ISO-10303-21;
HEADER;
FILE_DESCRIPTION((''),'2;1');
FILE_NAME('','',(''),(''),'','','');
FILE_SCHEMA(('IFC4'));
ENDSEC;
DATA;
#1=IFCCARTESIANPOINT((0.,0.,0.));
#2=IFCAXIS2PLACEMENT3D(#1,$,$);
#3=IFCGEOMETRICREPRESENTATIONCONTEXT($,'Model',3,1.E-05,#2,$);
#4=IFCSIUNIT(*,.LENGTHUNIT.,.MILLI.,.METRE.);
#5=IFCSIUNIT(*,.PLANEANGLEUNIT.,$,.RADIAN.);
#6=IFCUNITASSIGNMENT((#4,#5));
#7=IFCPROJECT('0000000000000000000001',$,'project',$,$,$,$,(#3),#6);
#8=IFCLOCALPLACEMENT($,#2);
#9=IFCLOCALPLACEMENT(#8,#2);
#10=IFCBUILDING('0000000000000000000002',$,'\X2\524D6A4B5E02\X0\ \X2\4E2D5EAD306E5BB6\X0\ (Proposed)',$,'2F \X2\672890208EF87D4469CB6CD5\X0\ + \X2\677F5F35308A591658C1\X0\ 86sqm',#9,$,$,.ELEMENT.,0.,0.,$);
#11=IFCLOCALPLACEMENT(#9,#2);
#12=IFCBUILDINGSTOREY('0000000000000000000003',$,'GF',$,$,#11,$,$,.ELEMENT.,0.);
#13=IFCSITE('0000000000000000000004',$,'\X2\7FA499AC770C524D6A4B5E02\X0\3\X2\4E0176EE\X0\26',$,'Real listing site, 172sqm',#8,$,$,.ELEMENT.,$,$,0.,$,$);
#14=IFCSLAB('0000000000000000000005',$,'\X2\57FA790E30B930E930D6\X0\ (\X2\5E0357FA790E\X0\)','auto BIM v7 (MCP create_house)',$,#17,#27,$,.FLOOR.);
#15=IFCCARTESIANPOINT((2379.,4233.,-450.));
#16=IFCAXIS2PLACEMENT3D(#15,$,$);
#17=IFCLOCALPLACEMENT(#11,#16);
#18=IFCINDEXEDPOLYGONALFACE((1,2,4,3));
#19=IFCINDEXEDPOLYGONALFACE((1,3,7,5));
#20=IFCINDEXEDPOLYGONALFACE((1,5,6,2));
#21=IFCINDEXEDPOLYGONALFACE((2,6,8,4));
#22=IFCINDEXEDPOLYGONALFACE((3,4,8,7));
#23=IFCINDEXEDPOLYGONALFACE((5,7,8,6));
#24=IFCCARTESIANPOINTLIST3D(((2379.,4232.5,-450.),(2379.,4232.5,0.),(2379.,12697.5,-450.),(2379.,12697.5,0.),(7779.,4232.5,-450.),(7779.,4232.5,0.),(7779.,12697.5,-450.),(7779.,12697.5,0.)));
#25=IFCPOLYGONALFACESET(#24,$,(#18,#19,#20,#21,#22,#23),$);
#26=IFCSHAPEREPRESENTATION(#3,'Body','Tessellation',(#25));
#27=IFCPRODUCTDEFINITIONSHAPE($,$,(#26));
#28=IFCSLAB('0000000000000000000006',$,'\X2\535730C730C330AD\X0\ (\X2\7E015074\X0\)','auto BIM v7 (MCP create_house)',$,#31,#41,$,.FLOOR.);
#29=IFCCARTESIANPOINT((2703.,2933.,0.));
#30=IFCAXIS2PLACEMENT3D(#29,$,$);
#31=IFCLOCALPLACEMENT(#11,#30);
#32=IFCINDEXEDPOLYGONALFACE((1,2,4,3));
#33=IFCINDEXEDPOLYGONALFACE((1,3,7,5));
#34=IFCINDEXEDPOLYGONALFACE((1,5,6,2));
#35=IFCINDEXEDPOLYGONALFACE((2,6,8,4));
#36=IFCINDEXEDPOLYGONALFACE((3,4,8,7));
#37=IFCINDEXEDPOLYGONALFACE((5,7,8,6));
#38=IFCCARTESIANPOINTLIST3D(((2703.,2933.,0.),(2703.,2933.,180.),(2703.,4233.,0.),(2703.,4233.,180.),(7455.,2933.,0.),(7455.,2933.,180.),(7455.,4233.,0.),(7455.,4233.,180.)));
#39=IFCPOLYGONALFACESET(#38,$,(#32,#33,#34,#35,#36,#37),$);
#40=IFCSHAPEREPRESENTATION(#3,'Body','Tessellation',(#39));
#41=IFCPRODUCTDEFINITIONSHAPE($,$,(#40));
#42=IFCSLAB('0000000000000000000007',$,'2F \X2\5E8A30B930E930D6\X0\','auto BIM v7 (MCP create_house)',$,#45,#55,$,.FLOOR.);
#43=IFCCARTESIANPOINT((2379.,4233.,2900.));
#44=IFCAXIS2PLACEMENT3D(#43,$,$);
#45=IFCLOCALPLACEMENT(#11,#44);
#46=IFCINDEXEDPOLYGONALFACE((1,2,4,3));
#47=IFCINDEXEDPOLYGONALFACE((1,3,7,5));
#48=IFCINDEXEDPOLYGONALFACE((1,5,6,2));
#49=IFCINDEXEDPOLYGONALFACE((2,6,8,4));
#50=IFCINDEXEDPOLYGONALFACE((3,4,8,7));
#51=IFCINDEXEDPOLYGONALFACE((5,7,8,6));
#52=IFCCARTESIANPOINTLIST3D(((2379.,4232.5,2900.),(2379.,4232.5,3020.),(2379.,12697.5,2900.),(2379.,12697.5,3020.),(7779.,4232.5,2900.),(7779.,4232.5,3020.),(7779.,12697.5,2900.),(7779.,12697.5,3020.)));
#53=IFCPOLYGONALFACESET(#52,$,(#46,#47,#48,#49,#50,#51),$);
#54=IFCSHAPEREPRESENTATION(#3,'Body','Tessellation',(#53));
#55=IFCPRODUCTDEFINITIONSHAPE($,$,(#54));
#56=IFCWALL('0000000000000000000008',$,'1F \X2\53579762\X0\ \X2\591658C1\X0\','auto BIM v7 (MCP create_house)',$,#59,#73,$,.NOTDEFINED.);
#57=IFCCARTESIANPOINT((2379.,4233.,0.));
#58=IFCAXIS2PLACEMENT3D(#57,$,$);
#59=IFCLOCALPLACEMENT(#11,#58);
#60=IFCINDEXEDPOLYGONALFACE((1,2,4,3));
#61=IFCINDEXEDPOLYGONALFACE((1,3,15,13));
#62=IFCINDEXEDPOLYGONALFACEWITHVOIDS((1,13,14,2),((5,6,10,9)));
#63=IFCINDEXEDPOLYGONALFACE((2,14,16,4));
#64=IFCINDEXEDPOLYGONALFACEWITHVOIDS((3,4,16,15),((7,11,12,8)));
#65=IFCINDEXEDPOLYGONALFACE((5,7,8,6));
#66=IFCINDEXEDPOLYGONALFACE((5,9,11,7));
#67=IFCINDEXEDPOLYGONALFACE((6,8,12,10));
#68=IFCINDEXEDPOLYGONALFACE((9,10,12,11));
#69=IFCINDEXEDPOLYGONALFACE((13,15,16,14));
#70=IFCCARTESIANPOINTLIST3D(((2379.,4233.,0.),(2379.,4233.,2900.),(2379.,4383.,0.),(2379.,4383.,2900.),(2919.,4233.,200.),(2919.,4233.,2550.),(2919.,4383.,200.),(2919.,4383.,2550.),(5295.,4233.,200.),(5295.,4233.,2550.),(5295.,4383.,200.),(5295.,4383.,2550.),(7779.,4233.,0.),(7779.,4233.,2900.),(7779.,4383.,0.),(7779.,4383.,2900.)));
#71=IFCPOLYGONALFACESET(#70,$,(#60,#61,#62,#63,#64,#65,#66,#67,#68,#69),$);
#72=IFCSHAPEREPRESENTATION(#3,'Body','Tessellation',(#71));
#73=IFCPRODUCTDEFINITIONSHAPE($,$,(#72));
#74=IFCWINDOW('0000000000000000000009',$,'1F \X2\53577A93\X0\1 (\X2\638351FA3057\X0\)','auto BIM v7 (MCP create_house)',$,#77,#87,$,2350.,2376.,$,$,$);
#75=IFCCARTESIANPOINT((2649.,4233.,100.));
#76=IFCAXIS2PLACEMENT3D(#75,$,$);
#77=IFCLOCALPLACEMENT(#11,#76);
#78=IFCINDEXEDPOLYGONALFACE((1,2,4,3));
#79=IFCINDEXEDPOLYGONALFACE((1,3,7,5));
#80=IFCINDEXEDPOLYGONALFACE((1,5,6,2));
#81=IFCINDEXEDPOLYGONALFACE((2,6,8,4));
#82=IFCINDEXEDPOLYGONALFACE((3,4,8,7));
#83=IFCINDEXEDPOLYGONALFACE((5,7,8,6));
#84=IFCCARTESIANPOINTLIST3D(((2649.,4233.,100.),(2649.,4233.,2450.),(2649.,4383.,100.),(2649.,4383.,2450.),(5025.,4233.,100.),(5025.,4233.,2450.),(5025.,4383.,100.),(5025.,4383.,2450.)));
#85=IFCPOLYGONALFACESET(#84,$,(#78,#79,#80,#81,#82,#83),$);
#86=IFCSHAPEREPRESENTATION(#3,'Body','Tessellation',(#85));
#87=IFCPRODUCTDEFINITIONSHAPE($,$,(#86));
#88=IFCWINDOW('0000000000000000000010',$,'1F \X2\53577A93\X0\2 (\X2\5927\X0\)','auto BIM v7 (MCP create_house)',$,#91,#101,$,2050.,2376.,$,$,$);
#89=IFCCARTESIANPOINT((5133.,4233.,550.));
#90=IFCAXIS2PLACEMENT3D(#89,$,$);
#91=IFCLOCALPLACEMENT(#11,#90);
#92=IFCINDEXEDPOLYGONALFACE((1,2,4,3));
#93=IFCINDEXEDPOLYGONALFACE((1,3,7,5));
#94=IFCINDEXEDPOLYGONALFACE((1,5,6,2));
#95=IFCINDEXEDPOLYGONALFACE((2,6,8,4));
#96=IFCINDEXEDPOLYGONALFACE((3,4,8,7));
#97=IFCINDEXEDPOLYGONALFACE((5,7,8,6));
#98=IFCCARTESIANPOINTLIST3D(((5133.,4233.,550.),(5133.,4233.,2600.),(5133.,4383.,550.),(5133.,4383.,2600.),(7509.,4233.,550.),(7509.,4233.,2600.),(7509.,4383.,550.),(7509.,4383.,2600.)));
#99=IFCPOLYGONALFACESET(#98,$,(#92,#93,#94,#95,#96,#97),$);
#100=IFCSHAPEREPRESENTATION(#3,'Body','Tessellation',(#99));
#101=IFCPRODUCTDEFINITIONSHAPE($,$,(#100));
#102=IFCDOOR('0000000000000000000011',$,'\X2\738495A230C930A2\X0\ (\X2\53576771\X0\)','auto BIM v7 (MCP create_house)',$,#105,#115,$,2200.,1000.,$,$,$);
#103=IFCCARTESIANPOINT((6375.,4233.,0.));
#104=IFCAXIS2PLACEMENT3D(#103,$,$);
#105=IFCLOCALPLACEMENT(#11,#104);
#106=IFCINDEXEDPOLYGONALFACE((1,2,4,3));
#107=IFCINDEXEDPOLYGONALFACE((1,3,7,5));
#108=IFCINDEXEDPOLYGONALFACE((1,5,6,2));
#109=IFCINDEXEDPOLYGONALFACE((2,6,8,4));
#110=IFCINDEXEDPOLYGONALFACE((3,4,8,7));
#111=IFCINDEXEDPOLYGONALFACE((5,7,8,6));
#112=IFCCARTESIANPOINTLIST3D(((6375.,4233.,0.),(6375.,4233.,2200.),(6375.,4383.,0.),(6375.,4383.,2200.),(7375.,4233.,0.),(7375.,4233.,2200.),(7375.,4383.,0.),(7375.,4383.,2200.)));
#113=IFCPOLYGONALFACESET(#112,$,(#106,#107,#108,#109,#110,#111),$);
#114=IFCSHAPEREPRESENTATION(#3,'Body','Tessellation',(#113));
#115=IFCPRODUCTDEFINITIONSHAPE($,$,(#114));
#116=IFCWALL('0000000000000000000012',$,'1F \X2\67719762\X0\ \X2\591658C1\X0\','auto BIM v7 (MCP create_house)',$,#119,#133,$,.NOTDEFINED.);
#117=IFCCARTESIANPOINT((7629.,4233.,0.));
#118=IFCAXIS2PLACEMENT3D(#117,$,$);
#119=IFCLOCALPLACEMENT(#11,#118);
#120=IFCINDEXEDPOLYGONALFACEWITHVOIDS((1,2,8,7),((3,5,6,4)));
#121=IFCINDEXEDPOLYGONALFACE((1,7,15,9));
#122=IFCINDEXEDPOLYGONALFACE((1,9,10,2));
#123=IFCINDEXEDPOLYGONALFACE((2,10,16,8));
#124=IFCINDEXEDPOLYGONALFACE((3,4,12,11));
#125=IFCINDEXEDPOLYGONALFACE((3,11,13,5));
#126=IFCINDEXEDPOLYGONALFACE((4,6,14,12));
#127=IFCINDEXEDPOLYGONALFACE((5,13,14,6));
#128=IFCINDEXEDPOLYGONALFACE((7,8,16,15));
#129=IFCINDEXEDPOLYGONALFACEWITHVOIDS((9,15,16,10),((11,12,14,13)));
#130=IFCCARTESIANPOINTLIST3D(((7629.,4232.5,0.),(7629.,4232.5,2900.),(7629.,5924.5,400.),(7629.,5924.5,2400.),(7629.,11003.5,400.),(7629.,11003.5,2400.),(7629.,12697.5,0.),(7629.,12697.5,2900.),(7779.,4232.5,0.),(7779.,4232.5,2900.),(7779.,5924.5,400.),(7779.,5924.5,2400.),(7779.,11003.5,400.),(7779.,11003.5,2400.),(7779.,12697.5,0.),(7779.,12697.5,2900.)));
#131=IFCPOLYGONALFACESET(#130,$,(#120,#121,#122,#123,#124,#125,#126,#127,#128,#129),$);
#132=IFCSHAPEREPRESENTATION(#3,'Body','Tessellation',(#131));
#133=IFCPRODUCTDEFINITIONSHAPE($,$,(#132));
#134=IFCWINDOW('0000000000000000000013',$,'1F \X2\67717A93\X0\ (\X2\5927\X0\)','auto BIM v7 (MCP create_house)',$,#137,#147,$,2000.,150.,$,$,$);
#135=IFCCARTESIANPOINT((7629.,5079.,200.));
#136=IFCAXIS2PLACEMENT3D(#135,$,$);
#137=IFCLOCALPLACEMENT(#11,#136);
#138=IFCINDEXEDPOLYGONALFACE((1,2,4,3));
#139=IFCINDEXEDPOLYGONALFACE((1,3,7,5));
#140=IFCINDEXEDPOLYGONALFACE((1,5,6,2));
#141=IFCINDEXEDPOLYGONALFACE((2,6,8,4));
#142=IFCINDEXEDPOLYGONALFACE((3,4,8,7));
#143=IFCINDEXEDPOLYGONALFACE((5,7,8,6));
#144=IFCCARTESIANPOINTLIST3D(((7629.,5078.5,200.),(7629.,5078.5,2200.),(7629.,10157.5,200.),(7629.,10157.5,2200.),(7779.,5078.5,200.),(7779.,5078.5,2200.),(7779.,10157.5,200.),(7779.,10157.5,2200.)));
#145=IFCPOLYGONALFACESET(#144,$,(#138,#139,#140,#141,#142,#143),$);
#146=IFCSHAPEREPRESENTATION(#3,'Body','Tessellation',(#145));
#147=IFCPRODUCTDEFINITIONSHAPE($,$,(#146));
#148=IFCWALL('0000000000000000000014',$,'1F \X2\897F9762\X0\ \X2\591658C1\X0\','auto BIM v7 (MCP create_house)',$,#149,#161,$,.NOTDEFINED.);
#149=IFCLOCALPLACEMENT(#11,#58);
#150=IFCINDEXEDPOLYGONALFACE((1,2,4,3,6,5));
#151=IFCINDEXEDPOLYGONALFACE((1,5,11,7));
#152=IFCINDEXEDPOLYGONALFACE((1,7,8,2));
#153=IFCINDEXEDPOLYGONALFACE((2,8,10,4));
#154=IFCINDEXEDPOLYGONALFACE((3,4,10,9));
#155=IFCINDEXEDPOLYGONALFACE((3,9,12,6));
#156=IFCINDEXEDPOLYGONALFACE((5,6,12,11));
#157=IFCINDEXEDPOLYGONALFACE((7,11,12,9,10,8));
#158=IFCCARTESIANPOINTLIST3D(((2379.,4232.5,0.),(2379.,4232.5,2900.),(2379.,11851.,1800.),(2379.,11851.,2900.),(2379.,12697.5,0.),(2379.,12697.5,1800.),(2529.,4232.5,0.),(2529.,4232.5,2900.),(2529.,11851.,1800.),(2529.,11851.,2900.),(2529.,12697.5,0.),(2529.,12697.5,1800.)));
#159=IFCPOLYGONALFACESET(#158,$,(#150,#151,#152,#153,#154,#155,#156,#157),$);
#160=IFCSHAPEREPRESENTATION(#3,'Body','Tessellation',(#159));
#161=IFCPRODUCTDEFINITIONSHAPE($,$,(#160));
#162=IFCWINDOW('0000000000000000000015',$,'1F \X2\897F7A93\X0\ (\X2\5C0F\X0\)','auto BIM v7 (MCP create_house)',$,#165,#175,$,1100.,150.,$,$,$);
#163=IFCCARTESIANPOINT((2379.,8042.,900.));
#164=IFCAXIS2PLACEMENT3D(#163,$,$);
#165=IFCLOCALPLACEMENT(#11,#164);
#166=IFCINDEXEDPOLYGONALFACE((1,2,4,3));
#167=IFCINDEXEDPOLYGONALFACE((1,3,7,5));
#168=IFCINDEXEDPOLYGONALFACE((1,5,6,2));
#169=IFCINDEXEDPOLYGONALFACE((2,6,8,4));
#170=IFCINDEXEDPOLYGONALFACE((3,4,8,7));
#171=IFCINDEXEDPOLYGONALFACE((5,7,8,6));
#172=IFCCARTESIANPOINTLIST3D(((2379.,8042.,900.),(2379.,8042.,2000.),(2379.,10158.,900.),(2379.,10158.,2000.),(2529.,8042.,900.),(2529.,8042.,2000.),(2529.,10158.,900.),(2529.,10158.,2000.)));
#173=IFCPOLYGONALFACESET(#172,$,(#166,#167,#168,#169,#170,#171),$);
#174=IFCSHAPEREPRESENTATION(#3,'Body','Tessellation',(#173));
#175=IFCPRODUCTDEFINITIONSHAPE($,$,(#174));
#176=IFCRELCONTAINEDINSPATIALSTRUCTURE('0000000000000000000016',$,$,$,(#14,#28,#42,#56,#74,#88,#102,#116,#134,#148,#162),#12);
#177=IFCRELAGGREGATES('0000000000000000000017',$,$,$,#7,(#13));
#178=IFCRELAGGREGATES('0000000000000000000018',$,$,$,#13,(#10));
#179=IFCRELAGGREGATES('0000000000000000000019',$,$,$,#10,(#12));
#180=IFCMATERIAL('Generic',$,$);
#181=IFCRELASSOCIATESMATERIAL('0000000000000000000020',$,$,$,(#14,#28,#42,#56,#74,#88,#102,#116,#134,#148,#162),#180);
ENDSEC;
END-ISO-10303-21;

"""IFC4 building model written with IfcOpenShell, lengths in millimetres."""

from ifc_helpers import new_model, si_unit, frame, frame_2d, origin, place, context, project, spatial, rectangle, extrude, material, element, fill, save


model = new_model("IFC4")

# Units and contexts
model_context = context("Model", 3, precision=1e-05, world=origin())
ifc_project = project(units=[si_unit("LENGTHUNIT", "METRE", prefix="MILLI"), si_unit("PLANEANGLEUNIT", "RADIAN")], contexts=[model_context])

# Site, building, storey
site_placement = place(None, origin())
site = spatial("IfcSite", under=ifc_project, at=site_placement, Name="群馬県前橋市3丁目26", ObjectType="Real listing site, 172sqm", CompositionType="ELEMENT", RefElevation=0.0)
building_placement = place(site_placement, origin())
building = spatial("IfcBuilding", under=site, at=building_placement, Name="前橋市 中庭の家 (Proposed)", ObjectType="2F 木造軸組構法 + 板張り外壁 86sqm", CompositionType="ELEMENT", ElevationOfRefHeight=0.0, ElevationOfTerrain=0.0)
storey_placement = place(building_placement, origin())
storey = spatial("IfcBuildingStorey", under=building, at=storey_placement, Name="GF", CompositionType="ELEMENT", Elevation=0.0)

# Slabs
ifc_material = material(Name="Generic")
slab_1_placement = place(storey_placement, frame((2379.0, 4233.0, -450.0)))
element("IfcSlab", 1, at=slab_1_placement, inside=storey, material=ifc_material, Name="基礎スラブ (布基礎)", Description="auto BIM v7 (MCP create_house)", PredefinedType="FLOOR", context=model_context, shape_type="SweptSolid", body=[
    extrude(rectangle(XDim=5400.0, YDim=8465.0, at=frame_2d((2700.0, 4232.0))), frame((2379.0, 4233.0, -450.0)), (0.0, 0.0, 1.0), 450.0),
])
slab_2_placement = place(storey_placement, frame((2703.0, 2933.0, 0.0)))
element("IfcSlab", 2, at=slab_2_placement, inside=storey, material=ifc_material, Name="南デッキ (縁側)", Description="auto BIM v7 (MCP create_house)", PredefinedType="FLOOR", context=model_context, shape_type="SweptSolid", body=[
    extrude(rectangle(XDim=4752.0, YDim=1300.0, at=frame_2d((2376.0, 650.0))), frame((2703.0, 2933.0, 0.0)), (0.0, 0.0, 1.0), 180.0),
])
slab_3_placement = place(storey_placement, frame((2379.0, 4233.0, 2900.0)))
element("IfcSlab", 3, at=slab_3_placement, inside=storey, material=ifc_material, Name="2F 床スラブ", Description="auto BIM v7 (MCP create_house)", PredefinedType="FLOOR", context=model_context, shape_type="SweptSolid", body=[
    extrude(rectangle(XDim=5400.0, YDim=8465.0, at=frame_2d((2700.0, 4232.0))), frame((2379.0, 4233.0, 2900.0)), (0.0, 0.0, 1.0), 120.0),
])

# Wall, openings, windows, door
wall_1_placement = place(storey_placement, frame((2379.0, 4233.0, 0.0)))
wall_1 = element("IfcWall", 4, at=wall_1_placement, inside=storey, material=ifc_material, Name="1F 南面 外壁", Description="auto BIM v7 (MCP create_house)", PredefinedType="NOTDEFINED", context=model_context, shape_type="SweptSolid", body=[
    extrude(rectangle(XDim=5400.0, YDim=150.0, at=frame_2d((2700.0, 75.0))), frame((2379.0, 4233.0, 0.0)), (0.0, 0.0, 1.0), 2900.0),
])
opening_1_placement = place(storey_placement, frame((2649.0, 4233.0, 100.0)))
opening_1 = element("IfcOpeningElement", 5, at=opening_1_placement, cuts=wall_1, PredefinedType="NOTDEFINED", context=model_context, shape_type="SweptSolid", body=[
    extrude(rectangle(XDim=2376.0, YDim=150.0, at=frame_2d((1188.0, 75.0))), frame((2649.0, 4233.0, 100.0)), (0.0, 0.0, 1.0), 2350.0),
])
opening_2_placement = place(storey_placement, frame((5133.0, 4233.0, 550.0)))
opening_2 = element("IfcOpeningElement", 6, at=opening_2_placement, cuts=wall_1, PredefinedType="NOTDEFINED", context=model_context, shape_type="SweptSolid", body=[
    extrude(rectangle(XDim=2376.0, YDim=150.0, at=frame_2d((1188.0, 75.0))), frame((5133.0, 4233.0, 550.0)), (0.0, 0.0, 1.0), 2050.0),
])
opening_3_placement = place(storey_placement, frame((6375.0, 4233.0, 0.0)))
opening_3 = element("IfcOpeningElement", 7, at=opening_3_placement, cuts=wall_1, PredefinedType="NOTDEFINED", context=model_context, shape_type="SweptSolid", body=[
    extrude(rectangle(XDim=1000.0, YDim=150.0, at=frame_2d((500.0, 75.0))), frame((6375.0, 4233.0, 0.0)), (0.0, 0.0, 1.0), 2200.0),
])
window_1_placement = place(storey_placement, frame((2649.0, 4233.0, 100.0)))
window_1 = element("IfcWindow", 8, at=window_1_placement, inside=storey, material=ifc_material, Name="1F 南窓1 (掃出し)", Description="auto BIM v7 (MCP create_house)", OverallHeight=2350.0, OverallWidth=2376.0, context=model_context, shape_type="SweptSolid", body=[
    extrude(rectangle(XDim=2376.0, YDim=150.0, at=frame_2d((1188.0, 75.0))), frame((2649.0, 4233.0, 100.0)), (0.0, 0.0, 1.0), 2350.0),
])
fill(opening_1, window_1)
window_2_placement = place(storey_placement, frame((5133.0, 4233.0, 550.0)))
window_2 = element("IfcWindow", 9, at=window_2_placement, inside=storey, material=ifc_material, Name="1F 南窓2 (大)", Description="auto BIM v7 (MCP create_house)", OverallHeight=2050.0, OverallWidth=2376.0, context=model_context, shape_type="SweptSolid", body=[
    extrude(rectangle(XDim=2376.0, YDim=150.0, at=frame_2d((1188.0, 75.0))), frame((5133.0, 4233.0, 550.0)), (0.0, 0.0, 1.0), 2050.0),
])
fill(opening_2, window_2)
door_placement = place(storey_placement, frame((6375.0, 4233.0, 0.0)))
door = element("IfcDoor", 10, at=door_placement, inside=storey, material=ifc_material, Name="玄関ドア (南東)", Description="auto BIM v7 (MCP create_house)", OverallHeight=2200.0, OverallWidth=1000.0, context=model_context, shape_type="SweptSolid", body=[
    extrude(rectangle(XDim=1000.0, YDim=150.0, at=frame_2d((500.0, 75.0))), frame((6375.0, 4233.0, 0.0)), (0.0, 0.0, 1.0), 2200.0),
])
fill(opening_3, door)

# Walls, openings, windows
wall_2_placement = place(storey_placement, frame((7629.0, 4233.0, 0.0)))
wall_2 = element("IfcWall", 11, at=wall_2_placement, inside=storey, material=ifc_material, Name="1F 東面 外壁", Description="auto BIM v7 (MCP create_house)", PredefinedType="NOTDEFINED", context=model_context, shape_type="SweptSolid", body=[
    extrude(rectangle(XDim=150.0, YDim=8465.0, at=frame_2d((75.0, 4232.0))), frame((7629.0, 4233.0, 0.0)), (0.0, 0.0, 1.0), 2900.0),
])
opening_4_placement = place(storey_placement, frame((7629.0, 5079.0, 200.0)))
opening_4 = element("IfcOpeningElement", 12, at=opening_4_placement, cuts=wall_2, PredefinedType="NOTDEFINED", context=model_context, shape_type="SweptSolid", body=[
    extrude(rectangle(XDim=150.0, YDim=5079.0, at=frame_2d((75.0, 2539.0))), frame((7629.0, 5079.0, 200.0)), (0.0, 0.0, 1.0), 2000.0),
])
window_3_placement = place(storey_placement, frame((7629.0, 5079.0, 200.0)))
window_3 = element("IfcWindow", 13, at=window_3_placement, inside=storey, material=ifc_material, Name="1F 東窓 (大)", Description="auto BIM v7 (MCP create_house)", OverallHeight=2000.0, OverallWidth=150.0, context=model_context, shape_type="SweptSolid", body=[
    extrude(rectangle(XDim=150.0, YDim=5079.0, at=frame_2d((75.0, 2539.0))), frame((7629.0, 5079.0, 200.0)), (0.0, 0.0, 1.0), 2000.0),
])
fill(opening_4, window_3)
wall_3_placement = place(storey_placement, frame((2379.0, 4233.0, 0.0)))
wall_3 = element("IfcWall", 14, at=wall_3_placement, inside=storey, material=ifc_material, Name="1F 西面 外壁", Description="auto BIM v7 (MCP create_house)", PredefinedType="NOTDEFINED", context=model_context, shape_type="SweptSolid", body=[
    extrude(rectangle(XDim=150.0, YDim=8465.0, at=frame_2d((75.0, 4232.0))), frame((2379.0, 4233.0, 0.0)), (0.0, 0.0, 1.0), 2900.0),
])
opening_5_placement = place(storey_placement, frame((2379.0, 8042.0, 900.0)))
opening_5 = element("IfcOpeningElement", 15, at=opening_5_placement, cuts=wall_3, PredefinedType="NOTDEFINED", context=model_context, shape_type="SweptSolid", body=[
    extrude(rectangle(XDim=150.0, YDim=2116.0, at=frame_2d((75.0, 1058.0))), frame((2379.0, 8042.0, 900.0)), (0.0, 0.0, 1.0), 1100.0),
])
window_4_placement = place(storey_placement, frame((2379.0, 8042.0, 900.0)))
window_4 = element("IfcWindow", 16, at=window_4_placement, inside=storey, material=ifc_material, Name="1F 西窓 (小)", Description="auto BIM v7 (MCP create_house)", OverallHeight=1100.0, OverallWidth=150.0, context=model_context, shape_type="SweptSolid", body=[
    extrude(rectangle(XDim=150.0, YDim=2116.0, at=frame_2d((75.0, 1058.0))), frame((2379.0, 8042.0, 900.0)), (0.0, 0.0, 1.0), 1100.0),
])
fill(opening_5, window_4)

save(model, "model.ifc")
